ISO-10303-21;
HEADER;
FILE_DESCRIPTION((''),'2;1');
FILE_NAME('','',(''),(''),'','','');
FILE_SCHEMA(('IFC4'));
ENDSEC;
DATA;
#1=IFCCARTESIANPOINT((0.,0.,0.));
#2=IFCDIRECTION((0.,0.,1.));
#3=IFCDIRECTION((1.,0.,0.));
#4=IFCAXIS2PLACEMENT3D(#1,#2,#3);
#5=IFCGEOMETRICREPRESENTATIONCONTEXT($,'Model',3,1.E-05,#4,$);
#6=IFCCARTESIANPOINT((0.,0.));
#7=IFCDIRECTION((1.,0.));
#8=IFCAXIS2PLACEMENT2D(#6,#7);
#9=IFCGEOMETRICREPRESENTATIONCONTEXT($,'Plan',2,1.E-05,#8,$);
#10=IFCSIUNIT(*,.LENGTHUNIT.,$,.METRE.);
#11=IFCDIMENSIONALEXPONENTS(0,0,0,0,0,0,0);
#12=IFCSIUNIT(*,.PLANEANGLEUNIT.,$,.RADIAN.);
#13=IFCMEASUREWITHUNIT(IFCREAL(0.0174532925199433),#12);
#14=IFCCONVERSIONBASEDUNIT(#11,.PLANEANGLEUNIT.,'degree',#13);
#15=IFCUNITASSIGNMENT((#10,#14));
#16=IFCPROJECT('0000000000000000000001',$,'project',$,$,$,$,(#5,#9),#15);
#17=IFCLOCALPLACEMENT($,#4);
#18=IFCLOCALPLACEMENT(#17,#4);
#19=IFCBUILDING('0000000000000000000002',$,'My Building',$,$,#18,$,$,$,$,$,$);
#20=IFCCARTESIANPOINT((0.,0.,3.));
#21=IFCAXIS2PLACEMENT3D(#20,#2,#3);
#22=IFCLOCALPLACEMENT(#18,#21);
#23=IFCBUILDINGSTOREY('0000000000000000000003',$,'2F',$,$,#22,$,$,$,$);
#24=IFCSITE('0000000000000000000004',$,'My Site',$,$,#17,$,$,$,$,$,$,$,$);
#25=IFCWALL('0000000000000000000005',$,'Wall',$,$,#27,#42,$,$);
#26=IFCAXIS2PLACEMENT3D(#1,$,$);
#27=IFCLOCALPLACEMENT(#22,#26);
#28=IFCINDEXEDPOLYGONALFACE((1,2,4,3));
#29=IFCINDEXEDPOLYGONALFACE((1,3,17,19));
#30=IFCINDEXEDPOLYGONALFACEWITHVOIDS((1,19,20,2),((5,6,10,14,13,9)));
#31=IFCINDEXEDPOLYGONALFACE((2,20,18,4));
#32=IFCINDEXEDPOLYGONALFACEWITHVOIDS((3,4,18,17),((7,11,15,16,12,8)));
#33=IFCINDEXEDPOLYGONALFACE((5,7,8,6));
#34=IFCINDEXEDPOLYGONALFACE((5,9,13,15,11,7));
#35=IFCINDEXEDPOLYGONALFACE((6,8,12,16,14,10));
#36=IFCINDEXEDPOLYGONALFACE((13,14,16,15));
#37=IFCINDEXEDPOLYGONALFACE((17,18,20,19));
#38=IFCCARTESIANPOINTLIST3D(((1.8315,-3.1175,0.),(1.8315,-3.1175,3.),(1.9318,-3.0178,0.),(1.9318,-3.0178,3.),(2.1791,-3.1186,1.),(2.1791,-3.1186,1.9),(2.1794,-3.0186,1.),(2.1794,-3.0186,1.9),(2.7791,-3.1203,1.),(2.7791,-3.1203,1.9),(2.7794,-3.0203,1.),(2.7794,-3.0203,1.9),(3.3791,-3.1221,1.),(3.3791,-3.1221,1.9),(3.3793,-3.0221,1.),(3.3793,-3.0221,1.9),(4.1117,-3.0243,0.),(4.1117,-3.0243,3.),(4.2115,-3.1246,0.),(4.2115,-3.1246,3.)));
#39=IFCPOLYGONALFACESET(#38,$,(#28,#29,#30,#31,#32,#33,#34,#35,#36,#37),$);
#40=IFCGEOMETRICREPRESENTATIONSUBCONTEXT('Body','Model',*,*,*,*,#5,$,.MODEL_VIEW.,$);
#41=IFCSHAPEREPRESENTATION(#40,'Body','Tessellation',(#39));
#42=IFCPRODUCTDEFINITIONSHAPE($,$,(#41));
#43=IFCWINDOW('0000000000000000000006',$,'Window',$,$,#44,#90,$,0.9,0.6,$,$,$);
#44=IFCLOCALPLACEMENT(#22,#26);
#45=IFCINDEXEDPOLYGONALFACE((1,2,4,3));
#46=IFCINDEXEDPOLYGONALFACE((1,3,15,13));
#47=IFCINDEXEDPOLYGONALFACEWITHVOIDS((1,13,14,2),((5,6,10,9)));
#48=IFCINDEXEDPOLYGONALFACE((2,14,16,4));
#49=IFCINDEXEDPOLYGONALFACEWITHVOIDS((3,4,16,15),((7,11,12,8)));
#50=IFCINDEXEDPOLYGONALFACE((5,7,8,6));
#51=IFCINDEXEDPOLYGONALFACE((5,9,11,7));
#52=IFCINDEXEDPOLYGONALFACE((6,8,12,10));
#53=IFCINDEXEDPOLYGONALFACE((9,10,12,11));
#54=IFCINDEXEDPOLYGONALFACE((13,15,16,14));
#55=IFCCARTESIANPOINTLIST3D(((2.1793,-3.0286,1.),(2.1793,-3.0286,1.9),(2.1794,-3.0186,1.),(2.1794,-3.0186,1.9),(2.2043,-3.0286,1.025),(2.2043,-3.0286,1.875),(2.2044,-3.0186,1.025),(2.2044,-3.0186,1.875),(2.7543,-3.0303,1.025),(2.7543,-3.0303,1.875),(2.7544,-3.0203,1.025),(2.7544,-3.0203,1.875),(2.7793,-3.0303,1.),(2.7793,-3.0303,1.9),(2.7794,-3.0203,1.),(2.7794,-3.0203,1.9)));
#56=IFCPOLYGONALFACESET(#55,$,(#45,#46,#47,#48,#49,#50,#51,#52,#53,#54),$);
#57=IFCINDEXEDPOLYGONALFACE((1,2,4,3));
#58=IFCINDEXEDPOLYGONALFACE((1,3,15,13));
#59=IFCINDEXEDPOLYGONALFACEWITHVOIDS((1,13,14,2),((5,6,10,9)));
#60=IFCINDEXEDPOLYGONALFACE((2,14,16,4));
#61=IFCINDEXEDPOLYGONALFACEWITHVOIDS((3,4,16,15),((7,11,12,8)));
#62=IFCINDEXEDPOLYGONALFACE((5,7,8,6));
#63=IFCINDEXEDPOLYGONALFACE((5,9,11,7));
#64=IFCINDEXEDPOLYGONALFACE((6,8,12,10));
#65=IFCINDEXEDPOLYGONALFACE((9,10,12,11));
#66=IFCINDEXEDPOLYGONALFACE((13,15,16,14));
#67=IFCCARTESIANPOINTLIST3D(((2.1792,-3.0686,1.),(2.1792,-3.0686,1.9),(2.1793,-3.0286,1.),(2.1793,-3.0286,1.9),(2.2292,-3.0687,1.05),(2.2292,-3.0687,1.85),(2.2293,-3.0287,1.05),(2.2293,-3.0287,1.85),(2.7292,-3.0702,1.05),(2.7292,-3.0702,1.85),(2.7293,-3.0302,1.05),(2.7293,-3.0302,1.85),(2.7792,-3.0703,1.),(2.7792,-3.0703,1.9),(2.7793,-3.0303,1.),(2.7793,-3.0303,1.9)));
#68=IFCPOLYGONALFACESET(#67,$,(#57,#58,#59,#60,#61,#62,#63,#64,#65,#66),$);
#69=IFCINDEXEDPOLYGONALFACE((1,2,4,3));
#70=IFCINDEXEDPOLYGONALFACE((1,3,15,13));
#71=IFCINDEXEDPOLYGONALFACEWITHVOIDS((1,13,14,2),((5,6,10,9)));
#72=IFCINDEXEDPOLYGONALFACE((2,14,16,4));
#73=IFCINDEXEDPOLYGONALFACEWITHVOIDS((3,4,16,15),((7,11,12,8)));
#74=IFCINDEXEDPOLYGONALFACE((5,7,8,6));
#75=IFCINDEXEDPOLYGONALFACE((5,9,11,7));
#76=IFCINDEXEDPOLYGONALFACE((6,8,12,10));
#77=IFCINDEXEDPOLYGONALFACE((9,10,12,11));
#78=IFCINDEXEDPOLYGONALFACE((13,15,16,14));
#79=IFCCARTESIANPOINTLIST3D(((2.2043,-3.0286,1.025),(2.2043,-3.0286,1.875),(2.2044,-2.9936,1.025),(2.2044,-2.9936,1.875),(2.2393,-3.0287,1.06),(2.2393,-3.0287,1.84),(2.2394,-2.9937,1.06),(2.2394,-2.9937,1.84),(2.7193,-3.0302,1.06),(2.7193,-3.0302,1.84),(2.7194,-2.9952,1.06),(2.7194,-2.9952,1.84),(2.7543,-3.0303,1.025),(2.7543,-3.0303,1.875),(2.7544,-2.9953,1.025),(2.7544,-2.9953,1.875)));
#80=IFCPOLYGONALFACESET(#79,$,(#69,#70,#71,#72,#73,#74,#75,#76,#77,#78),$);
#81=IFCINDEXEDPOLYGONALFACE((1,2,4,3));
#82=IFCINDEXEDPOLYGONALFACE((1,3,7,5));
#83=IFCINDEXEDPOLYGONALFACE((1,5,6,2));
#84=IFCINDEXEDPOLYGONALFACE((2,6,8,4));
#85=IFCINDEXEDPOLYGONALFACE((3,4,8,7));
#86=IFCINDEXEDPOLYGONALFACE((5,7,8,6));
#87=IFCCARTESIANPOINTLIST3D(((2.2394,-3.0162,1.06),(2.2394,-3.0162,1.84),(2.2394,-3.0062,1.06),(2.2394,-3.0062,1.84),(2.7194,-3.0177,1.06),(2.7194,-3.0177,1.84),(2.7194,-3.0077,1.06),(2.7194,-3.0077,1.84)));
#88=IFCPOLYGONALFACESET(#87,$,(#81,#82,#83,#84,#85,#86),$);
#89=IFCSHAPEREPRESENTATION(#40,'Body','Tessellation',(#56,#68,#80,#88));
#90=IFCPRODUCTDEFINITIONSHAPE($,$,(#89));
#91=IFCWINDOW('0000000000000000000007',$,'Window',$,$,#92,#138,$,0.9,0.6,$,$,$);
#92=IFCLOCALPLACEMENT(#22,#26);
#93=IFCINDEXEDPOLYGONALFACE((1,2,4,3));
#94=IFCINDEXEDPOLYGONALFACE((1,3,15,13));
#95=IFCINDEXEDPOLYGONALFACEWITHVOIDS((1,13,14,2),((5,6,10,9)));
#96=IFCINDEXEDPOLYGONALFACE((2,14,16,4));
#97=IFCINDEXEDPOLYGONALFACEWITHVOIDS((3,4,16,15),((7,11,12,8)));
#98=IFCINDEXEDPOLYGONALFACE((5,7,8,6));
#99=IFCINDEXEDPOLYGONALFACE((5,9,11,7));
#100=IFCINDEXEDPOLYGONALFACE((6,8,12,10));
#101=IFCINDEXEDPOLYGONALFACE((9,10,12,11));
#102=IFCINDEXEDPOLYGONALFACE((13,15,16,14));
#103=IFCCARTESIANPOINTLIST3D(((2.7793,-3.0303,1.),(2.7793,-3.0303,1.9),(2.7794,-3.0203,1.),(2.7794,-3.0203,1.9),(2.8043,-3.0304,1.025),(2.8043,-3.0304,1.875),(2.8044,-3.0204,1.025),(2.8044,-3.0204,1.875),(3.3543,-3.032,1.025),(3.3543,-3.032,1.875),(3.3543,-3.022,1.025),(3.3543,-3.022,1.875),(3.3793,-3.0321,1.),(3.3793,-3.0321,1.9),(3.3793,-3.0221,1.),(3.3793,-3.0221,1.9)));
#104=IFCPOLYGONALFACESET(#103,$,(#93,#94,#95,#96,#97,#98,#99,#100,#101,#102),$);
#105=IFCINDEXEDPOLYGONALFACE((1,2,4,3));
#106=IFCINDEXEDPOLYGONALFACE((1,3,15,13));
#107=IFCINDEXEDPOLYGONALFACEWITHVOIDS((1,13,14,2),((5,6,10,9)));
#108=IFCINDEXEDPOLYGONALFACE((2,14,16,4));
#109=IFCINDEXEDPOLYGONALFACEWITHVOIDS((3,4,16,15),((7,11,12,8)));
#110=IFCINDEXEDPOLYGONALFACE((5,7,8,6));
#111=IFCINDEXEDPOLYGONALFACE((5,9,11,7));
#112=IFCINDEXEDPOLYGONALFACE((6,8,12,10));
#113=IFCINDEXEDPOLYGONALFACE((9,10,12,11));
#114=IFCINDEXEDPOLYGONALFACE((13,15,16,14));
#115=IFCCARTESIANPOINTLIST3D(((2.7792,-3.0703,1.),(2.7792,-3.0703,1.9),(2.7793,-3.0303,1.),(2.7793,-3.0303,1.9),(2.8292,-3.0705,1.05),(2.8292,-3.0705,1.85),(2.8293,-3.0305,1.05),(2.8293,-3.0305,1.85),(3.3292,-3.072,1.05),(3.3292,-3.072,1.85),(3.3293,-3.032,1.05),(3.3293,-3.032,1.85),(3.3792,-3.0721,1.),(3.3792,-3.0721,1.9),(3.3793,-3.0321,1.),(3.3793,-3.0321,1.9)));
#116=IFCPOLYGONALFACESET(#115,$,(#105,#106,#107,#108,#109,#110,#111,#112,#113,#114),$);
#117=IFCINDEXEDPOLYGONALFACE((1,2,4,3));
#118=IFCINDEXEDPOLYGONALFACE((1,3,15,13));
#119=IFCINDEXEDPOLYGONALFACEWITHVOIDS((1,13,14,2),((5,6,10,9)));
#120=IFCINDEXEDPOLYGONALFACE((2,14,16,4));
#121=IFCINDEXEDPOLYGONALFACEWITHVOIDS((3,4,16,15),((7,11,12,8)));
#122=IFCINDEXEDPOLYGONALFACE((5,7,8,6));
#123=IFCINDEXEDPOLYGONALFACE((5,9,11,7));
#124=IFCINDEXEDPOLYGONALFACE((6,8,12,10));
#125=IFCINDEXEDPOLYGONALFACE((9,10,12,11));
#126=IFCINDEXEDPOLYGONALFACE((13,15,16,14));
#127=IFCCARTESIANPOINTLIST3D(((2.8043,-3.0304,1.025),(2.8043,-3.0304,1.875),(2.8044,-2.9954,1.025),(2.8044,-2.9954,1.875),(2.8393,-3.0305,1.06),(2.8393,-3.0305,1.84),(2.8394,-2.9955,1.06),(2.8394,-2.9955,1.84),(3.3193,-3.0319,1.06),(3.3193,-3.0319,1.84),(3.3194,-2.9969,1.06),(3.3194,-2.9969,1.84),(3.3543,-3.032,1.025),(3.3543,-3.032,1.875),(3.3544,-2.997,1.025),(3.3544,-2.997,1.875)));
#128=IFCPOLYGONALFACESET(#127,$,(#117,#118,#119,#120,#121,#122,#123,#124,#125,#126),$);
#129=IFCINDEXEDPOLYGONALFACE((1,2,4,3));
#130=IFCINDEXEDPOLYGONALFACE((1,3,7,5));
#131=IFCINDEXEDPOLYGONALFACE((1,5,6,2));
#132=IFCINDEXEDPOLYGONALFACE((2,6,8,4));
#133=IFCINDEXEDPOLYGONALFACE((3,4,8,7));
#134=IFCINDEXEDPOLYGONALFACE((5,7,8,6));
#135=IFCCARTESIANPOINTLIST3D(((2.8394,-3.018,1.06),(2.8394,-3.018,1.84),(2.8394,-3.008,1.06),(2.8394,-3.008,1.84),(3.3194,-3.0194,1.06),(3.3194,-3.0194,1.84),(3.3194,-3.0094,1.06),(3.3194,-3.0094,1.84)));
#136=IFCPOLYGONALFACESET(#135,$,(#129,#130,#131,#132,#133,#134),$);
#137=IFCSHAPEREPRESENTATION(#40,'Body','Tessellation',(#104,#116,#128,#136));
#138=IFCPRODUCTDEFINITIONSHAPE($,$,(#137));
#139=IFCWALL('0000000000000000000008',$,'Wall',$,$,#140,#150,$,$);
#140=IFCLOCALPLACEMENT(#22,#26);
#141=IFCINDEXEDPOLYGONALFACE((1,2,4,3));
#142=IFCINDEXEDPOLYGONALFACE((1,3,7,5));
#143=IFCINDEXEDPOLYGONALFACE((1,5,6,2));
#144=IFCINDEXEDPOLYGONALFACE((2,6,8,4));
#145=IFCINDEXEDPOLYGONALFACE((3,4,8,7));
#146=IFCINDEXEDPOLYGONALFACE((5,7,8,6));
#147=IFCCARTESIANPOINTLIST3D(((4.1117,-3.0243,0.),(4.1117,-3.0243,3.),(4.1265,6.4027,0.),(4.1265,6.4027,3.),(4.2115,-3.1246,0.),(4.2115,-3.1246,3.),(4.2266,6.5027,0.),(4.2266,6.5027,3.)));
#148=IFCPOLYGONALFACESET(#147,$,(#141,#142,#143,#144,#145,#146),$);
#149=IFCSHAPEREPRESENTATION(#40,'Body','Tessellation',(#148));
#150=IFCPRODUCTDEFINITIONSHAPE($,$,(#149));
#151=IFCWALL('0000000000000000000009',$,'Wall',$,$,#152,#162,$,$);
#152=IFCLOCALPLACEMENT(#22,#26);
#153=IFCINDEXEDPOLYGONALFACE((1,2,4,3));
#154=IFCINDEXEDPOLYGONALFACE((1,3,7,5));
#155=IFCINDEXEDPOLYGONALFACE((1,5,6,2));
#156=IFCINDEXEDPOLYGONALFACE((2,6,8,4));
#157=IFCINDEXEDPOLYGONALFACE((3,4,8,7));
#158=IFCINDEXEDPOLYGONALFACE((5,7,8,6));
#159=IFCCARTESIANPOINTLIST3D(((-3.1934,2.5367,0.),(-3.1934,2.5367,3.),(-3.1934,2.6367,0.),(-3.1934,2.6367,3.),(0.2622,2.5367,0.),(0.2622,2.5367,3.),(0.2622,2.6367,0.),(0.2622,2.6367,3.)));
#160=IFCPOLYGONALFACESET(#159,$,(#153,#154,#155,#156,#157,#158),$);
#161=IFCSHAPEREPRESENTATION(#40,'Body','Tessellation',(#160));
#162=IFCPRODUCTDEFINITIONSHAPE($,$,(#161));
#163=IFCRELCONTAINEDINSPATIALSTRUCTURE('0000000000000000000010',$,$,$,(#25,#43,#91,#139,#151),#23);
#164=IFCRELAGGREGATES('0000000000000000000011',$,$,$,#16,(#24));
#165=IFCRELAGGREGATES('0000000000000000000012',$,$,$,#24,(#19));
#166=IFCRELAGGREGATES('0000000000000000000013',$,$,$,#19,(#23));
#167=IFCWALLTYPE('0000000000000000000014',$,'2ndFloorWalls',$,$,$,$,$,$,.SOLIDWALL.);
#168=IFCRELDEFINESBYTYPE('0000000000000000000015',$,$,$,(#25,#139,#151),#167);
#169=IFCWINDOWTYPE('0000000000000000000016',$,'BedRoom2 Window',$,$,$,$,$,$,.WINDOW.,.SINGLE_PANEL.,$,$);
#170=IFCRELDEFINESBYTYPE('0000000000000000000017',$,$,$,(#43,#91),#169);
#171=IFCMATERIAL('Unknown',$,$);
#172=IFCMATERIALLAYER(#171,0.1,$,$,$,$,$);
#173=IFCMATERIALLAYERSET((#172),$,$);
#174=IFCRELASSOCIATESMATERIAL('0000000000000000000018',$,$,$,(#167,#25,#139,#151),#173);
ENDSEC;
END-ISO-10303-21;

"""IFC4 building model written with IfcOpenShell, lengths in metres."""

from ifc_helpers import new_model, entity, si_unit, converted_unit, frame, origin_with_axes, origin_2d_with_axis, place, context, subcontext, project, spatial, line, indexed_curve, outline, extrude, shape, source, transform, mapped, material, layer, layer_set, layer_usage, type_object, type_shapes, element, fill, save


model = new_model("IFC4")

# Units and contexts
model_context = context("Model", 3, precision=1e-05, world=origin_with_axes())
plan_context = context("Plan", 2, precision=1e-05, world=origin_2d_with_axis())
body_context_1 = subcontext(model_context, "Body", "Model", "MODEL_VIEW")
body_context_2 = subcontext(plan_context, "Body", "Plan", "PLAN_VIEW")
ifc_project = project(units=[si_unit("LENGTHUNIT", "METRE"), converted_unit("PLANEANGLEUNIT", "degree", entity("IfcReal", 0.0174532925199433), si_unit("PLANEANGLEUNIT", "RADIAN"), dimensions=[0, 0, 0, 0, 0, 0, 0])], contexts=[model_context, plan_context])

# Site, building, storey
site_placement = place(None, origin_with_axes())
site = spatial("IfcSite", under=ifc_project, at=site_placement, Name="My Site")
building_placement = place(site_placement, origin_with_axes())
building = spatial("IfcBuilding", under=site, at=building_placement, Name="My Building")
storey_placement = place(building_placement, frame((0.0, 0.0, 3.0), z_axis=(0.0, 0.0, 1.0), x_axis=(1.0, 0.0, 0.0)))
storey = spatial("IfcBuildingStorey", under=building, at=storey_placement, Name="2F")

# Shared definitions
ifc_material = material(Name="Unknown")

# Shared definitions
ifc_layer_1 = layer(ifc_material, 0.1)
ifc_layer_set_1 = layer_set([ifc_layer_1])
wall_type = type_object("IfcWallType", Name="2ndFloorWalls", PredefinedType="SOLIDWALL", material=ifc_layer_set_1)

# Wall, openings, windows
ifc_layer_usage_1 = layer_usage(ifc_layer_set_1, "AXIS2", "POSITIVE", 0.0)
wall_1_placement = place(storey_placement, frame((1.8315, -3.1175, 0.0), z_axis=(0.0, 0.0, 1.0), x_axis=(0.999996, -0.002968, 0.0)))
wall_1 = element("IfcWall", 1, at=wall_1_placement, inside=storey, type_object=wall_type, material=ifc_layer_usage_1, Name="Wall", context=body_context_1, shape_type="SweptSolid", body=[
    extrude(outline(indexed_curve([(0.0, 0.0), (0.1, 0.1), (2.2799, 0.1), (2.38, 0.0)], segments=[line(1, 2, 3, 4, 1)])), origin_with_axes(), (0.0, 0.0, 1.0), 3.0),
])
shared_shape_1 = source(origin_with_axes(), body_context_1, "Body", "SweptSolid", [
    extrude(outline(indexed_curve([(0.0, 0.0), (0.6, 0.0), (0.6, 0.9), (0.0, 0.9)], segments=[line(1, 2, 3, 4, 1)])), frame((0.0, -0.6, 0.0), z_axis=(0.0, -1.0, 0.0), x_axis=(1.0, 0.0, 0.0)), (0.0, 0.0, -1.0), 1.2),
])
opening_1_placement = place(wall_1_placement, frame((0.3476, 0.0, 1.0), z_axis=(0.0, 0.0, 1.0), x_axis=(1.0, 0.0, 0.0)))
opening_1 = element("IfcOpeningElement", 2, at=opening_1_placement, cuts=wall_1, PredefinedType="OPENING", context=body_context_1, shape_type="MappedRepresentation", body=[
    mapped(shared_shape_1, transform((0.0, 0.0, 0.0), x_axis=(1.0, 0.0, 0.0), y_axis=(0.0, 1.0, 0.0), z_axis=(0.0, 0.0, 1.0), scale=1.0)),
])
opening_2_placement = place(wall_1_placement, frame((0.9476, 0.0, 1.0), z_axis=(0.0, 0.0, 1.0), x_axis=(1.0, 0.0, 0.0)))
opening_2 = element("IfcOpeningElement", 3, at=opening_2_placement, cuts=wall_1, PredefinedType="OPENING", context=body_context_1, shape_type="MappedRepresentation", body=[
    mapped(shared_shape_1, transform((0.0, 0.0, 0.0), x_axis=(1.0, 0.0, 0.0), y_axis=(0.0, 1.0, 0.0), z_axis=(0.0, 0.0, 1.0), scale=1.0)),
])
window_type_1 = type_object("IfcWindowType", Name="BedRoom2 Window", PartitioningType="SINGLE_PANEL", PredefinedType="WINDOW")
shared_shape_2 = source(origin_with_axes(), body_context_1, "Body", "SweptSolid", [
    extrude(outline(indexed_curve([(0.0, 0.0), (0.6, 0.0), (0.6, 0.9), (0.0, 0.9)], segments=[line(1, 2, 3, 4, 1)]), holes=[indexed_curve([(0.025, 0.025), (0.575, 0.025), (0.575, 0.875), (0.025, 0.875)], segments=[line(1, 2, 3, 4, 1)])]), frame((0.0, 0.09, 0.0), z_axis=(0.0, -1.0, 0.0), x_axis=(1.0, 0.0, 0.0)), (0.0, 0.0, -1.0), 0.01),
    extrude(outline(indexed_curve([(0.0, 0.0), (0.6, 0.0), (0.6, 0.9), (0.0, 0.9)], segments=[line(1, 2, 3, 4, 1)]), holes=[indexed_curve([(0.05, 0.05), (0.55, 0.05), (0.55, 0.85), (0.05, 0.85)], segments=[line(1, 2, 3, 4, 1)])]), frame((0.0, 0.05, 0.0), z_axis=(0.0, -1.0, 0.0), x_axis=(1.0, 0.0, 0.0)), (0.0, 0.0, -1.0), 0.04),
    extrude(outline(indexed_curve([(0.0, 0.0), (0.55, 0.0), (0.55, 0.85), (0.0, 0.85)], segments=[line(1, 2, 3, 4, 1)]), holes=[indexed_curve([(0.035, 0.035), (0.515, 0.035), (0.515, 0.815), (0.035, 0.815)], segments=[line(1, 2, 3, 4, 1)])]), frame((0.025, 0.09, 0.025), z_axis=(0.0, -1.0, 0.0), x_axis=(1.0, 0.0, 0.0)), (0.0, 0.0, -1.0), 0.035),
    extrude(outline(indexed_curve([(0.035, 0.035), (0.515, 0.035), (0.515, 0.815), (0.035, 0.815)], segments=[line(1, 2, 3, 4, 1)])), frame((0.025, 0.1025, 0.025), z_axis=(0.0, -1.0, 0.0), x_axis=(1.0, 0.0, 0.0)), (0.0, 0.0, -1.0), 0.01),
])
shared_shape_3 = source(origin_with_axes(), body_context_2, "Body", "Curve2D", [
    entity("IfcIndexedPolyCurve", entity("IfcCartesianPointList2D", [[0.05, 0.05], [0.55, 0.05]])),
    entity("IfcIndexedPolyCurve", entity("IfcCartesianPointList2D", [[0.0, 0.1], [0.025, 0.1], [0.025, 0.09], [0.05, 0.09], [0.05, 0.05], [0.0, 0.05]]), [entity("IfcLineIndex", [1, 2, 3, 4, 5, 6, 1])]),
    entity("IfcIndexedPolyCurve", entity("IfcCartesianPointList2D", [[0.6, 0.1], [0.575, 0.1], [0.575, 0.09], [0.55, 0.09], [0.55, 0.05], [0.6, 0.05]]), [entity("IfcLineIndex", [1, 2, 3, 4, 5, 6, 1])]),
    entity("IfcIndexedPolyCurve", entity("IfcCartesianPointList2D", [[0.025, 0.09], [0.06, 0.09], [0.06, 0.125], [0.025, 0.125]]), [entity("IfcLineIndex", [1, 2, 3, 4, 1])]),
    entity("IfcIndexedPolyCurve", entity("IfcCartesianPointList2D", [[0.575, 0.09], [0.54, 0.09], [0.54, 0.125], [0.575, 0.125]]), [entity("IfcLineIndex", [1, 2, 3, 4, 1])]),
    entity("IfcIndexedPolyCurve", entity("IfcCartesianPointList2D", [[0.06, 0.09], [0.54, 0.09]])),
    entity("IfcIndexedPolyCurve", entity("IfcCartesianPointList2D", [[0.06, 0.125], [0.54, 0.125]])),
    entity("IfcIndexedPolyCurve", entity("IfcCartesianPointList2D", [[0.06, 0.1075], [0.54, 0.1075]])),
])
type_shapes(window_type_1, [shared_shape_2, shared_shape_3])
window_1_placement = place(opening_1_placement, origin_with_axes())
window_1 = element("IfcWindow", 4, at=window_1_placement, inside=storey, type_object=window_type_1, Name="Window", OverallHeight=0.9, OverallWidth=0.6, shapes=[
    shape(body_context_1, "Body", "MappedRepresentation", [mapped(shared_shape_2, transform((0.0, 0.0, 0.0), x_axis=(1.0, 0.0, 0.0), y_axis=(0.0, 1.0, 0.0), z_axis=(0.0, 0.0, 1.0), scale=1.0))]),
    shape(body_context_2, "Body", "MappedRepresentation", [mapped(shared_shape_3, transform((0.0, 0.0, 0.0), x_axis=(1.0, 0.0, 0.0), y_axis=(0.0, 1.0, 0.0), z_axis=(0.0, 0.0, 1.0), scale=1.0))]),
])
fill(opening_1, window_1)
window_2_placement = place(opening_2_placement, frame((0.0, 0.0, 0.0), z_axis=(0.0, 0.0, 1.0), x_axis=(1.0, 0.0, 0.0)))
window_2 = element("IfcWindow", 5, at=window_2_placement, inside=storey, type_object=window_type_1, Name="Window", OverallHeight=0.9, OverallWidth=0.6, shapes=[
    shape(body_context_1, "Body", "MappedRepresentation", [mapped(shared_shape_2, transform((0.0, 0.0, 0.0), x_axis=(1.0, 0.0, 0.0), y_axis=(0.0, 1.0, 0.0), z_axis=(0.0, 0.0, 1.0), scale=1.0))]),
    shape(body_context_2, "Body", "MappedRepresentation", [mapped(shared_shape_3, transform((0.0, 0.0, 0.0), x_axis=(1.0, 0.0, 0.0), y_axis=(0.0, 1.0, 0.0), z_axis=(0.0, 0.0, 1.0), scale=1.0))]),
])
fill(opening_2, window_2)

# Wall
ifc_layer_usage_2 = layer_usage(ifc_layer_set_1, "AXIS2", "POSITIVE", 0.0)
wall_2_placement = place(storey_placement, frame((4.2115, -3.1246, 0.0), z_axis=(0.0, 0.0, 1.0), x_axis=(0.00157, 0.999999, 0.0)))
element("IfcWall", 6, at=wall_2_placement, inside=storey, type_object=wall_type, material=ifc_layer_usage_2, Name="Wall", context=body_context_1, shape_type="SweptSolid", body=[
    extrude(outline(indexed_curve([(0.0, 0.0), (0.1001, 0.1), (9.5272, 0.1), (9.6273, 0.0)], segments=[line(1, 2, 3, 4, 1)])), origin_with_axes(), (0.0, 0.0, 1.0), 3.0),
])

# Wall
ifc_layer_usage_3 = layer_usage(ifc_layer_set_1, "AXIS2", "POSITIVE", 0.0)
wall_3_placement = place(storey_placement, frame((-3.1934, 2.5367, 0.0), z_axis=(0.0, 0.0, 1.0), x_axis=(1.0, 0.000002, 0.0)))
element("IfcWall", 7, at=wall_3_placement, inside=storey, type_object=wall_type, material=ifc_layer_usage_3, Name="Wall", context=body_context_1, shape_type="SweptSolid", body=[
    extrude(outline(indexed_curve([(0.0, 0.0), (0.0, 0.1), (3.4556, 0.1), (3.4556, 0.0)], segments=[line(1, 2, 3, 4, 1)])), origin_with_axes(), (0.0, 0.0, 1.0), 3.0),
])

save(model, "model.ifc")
